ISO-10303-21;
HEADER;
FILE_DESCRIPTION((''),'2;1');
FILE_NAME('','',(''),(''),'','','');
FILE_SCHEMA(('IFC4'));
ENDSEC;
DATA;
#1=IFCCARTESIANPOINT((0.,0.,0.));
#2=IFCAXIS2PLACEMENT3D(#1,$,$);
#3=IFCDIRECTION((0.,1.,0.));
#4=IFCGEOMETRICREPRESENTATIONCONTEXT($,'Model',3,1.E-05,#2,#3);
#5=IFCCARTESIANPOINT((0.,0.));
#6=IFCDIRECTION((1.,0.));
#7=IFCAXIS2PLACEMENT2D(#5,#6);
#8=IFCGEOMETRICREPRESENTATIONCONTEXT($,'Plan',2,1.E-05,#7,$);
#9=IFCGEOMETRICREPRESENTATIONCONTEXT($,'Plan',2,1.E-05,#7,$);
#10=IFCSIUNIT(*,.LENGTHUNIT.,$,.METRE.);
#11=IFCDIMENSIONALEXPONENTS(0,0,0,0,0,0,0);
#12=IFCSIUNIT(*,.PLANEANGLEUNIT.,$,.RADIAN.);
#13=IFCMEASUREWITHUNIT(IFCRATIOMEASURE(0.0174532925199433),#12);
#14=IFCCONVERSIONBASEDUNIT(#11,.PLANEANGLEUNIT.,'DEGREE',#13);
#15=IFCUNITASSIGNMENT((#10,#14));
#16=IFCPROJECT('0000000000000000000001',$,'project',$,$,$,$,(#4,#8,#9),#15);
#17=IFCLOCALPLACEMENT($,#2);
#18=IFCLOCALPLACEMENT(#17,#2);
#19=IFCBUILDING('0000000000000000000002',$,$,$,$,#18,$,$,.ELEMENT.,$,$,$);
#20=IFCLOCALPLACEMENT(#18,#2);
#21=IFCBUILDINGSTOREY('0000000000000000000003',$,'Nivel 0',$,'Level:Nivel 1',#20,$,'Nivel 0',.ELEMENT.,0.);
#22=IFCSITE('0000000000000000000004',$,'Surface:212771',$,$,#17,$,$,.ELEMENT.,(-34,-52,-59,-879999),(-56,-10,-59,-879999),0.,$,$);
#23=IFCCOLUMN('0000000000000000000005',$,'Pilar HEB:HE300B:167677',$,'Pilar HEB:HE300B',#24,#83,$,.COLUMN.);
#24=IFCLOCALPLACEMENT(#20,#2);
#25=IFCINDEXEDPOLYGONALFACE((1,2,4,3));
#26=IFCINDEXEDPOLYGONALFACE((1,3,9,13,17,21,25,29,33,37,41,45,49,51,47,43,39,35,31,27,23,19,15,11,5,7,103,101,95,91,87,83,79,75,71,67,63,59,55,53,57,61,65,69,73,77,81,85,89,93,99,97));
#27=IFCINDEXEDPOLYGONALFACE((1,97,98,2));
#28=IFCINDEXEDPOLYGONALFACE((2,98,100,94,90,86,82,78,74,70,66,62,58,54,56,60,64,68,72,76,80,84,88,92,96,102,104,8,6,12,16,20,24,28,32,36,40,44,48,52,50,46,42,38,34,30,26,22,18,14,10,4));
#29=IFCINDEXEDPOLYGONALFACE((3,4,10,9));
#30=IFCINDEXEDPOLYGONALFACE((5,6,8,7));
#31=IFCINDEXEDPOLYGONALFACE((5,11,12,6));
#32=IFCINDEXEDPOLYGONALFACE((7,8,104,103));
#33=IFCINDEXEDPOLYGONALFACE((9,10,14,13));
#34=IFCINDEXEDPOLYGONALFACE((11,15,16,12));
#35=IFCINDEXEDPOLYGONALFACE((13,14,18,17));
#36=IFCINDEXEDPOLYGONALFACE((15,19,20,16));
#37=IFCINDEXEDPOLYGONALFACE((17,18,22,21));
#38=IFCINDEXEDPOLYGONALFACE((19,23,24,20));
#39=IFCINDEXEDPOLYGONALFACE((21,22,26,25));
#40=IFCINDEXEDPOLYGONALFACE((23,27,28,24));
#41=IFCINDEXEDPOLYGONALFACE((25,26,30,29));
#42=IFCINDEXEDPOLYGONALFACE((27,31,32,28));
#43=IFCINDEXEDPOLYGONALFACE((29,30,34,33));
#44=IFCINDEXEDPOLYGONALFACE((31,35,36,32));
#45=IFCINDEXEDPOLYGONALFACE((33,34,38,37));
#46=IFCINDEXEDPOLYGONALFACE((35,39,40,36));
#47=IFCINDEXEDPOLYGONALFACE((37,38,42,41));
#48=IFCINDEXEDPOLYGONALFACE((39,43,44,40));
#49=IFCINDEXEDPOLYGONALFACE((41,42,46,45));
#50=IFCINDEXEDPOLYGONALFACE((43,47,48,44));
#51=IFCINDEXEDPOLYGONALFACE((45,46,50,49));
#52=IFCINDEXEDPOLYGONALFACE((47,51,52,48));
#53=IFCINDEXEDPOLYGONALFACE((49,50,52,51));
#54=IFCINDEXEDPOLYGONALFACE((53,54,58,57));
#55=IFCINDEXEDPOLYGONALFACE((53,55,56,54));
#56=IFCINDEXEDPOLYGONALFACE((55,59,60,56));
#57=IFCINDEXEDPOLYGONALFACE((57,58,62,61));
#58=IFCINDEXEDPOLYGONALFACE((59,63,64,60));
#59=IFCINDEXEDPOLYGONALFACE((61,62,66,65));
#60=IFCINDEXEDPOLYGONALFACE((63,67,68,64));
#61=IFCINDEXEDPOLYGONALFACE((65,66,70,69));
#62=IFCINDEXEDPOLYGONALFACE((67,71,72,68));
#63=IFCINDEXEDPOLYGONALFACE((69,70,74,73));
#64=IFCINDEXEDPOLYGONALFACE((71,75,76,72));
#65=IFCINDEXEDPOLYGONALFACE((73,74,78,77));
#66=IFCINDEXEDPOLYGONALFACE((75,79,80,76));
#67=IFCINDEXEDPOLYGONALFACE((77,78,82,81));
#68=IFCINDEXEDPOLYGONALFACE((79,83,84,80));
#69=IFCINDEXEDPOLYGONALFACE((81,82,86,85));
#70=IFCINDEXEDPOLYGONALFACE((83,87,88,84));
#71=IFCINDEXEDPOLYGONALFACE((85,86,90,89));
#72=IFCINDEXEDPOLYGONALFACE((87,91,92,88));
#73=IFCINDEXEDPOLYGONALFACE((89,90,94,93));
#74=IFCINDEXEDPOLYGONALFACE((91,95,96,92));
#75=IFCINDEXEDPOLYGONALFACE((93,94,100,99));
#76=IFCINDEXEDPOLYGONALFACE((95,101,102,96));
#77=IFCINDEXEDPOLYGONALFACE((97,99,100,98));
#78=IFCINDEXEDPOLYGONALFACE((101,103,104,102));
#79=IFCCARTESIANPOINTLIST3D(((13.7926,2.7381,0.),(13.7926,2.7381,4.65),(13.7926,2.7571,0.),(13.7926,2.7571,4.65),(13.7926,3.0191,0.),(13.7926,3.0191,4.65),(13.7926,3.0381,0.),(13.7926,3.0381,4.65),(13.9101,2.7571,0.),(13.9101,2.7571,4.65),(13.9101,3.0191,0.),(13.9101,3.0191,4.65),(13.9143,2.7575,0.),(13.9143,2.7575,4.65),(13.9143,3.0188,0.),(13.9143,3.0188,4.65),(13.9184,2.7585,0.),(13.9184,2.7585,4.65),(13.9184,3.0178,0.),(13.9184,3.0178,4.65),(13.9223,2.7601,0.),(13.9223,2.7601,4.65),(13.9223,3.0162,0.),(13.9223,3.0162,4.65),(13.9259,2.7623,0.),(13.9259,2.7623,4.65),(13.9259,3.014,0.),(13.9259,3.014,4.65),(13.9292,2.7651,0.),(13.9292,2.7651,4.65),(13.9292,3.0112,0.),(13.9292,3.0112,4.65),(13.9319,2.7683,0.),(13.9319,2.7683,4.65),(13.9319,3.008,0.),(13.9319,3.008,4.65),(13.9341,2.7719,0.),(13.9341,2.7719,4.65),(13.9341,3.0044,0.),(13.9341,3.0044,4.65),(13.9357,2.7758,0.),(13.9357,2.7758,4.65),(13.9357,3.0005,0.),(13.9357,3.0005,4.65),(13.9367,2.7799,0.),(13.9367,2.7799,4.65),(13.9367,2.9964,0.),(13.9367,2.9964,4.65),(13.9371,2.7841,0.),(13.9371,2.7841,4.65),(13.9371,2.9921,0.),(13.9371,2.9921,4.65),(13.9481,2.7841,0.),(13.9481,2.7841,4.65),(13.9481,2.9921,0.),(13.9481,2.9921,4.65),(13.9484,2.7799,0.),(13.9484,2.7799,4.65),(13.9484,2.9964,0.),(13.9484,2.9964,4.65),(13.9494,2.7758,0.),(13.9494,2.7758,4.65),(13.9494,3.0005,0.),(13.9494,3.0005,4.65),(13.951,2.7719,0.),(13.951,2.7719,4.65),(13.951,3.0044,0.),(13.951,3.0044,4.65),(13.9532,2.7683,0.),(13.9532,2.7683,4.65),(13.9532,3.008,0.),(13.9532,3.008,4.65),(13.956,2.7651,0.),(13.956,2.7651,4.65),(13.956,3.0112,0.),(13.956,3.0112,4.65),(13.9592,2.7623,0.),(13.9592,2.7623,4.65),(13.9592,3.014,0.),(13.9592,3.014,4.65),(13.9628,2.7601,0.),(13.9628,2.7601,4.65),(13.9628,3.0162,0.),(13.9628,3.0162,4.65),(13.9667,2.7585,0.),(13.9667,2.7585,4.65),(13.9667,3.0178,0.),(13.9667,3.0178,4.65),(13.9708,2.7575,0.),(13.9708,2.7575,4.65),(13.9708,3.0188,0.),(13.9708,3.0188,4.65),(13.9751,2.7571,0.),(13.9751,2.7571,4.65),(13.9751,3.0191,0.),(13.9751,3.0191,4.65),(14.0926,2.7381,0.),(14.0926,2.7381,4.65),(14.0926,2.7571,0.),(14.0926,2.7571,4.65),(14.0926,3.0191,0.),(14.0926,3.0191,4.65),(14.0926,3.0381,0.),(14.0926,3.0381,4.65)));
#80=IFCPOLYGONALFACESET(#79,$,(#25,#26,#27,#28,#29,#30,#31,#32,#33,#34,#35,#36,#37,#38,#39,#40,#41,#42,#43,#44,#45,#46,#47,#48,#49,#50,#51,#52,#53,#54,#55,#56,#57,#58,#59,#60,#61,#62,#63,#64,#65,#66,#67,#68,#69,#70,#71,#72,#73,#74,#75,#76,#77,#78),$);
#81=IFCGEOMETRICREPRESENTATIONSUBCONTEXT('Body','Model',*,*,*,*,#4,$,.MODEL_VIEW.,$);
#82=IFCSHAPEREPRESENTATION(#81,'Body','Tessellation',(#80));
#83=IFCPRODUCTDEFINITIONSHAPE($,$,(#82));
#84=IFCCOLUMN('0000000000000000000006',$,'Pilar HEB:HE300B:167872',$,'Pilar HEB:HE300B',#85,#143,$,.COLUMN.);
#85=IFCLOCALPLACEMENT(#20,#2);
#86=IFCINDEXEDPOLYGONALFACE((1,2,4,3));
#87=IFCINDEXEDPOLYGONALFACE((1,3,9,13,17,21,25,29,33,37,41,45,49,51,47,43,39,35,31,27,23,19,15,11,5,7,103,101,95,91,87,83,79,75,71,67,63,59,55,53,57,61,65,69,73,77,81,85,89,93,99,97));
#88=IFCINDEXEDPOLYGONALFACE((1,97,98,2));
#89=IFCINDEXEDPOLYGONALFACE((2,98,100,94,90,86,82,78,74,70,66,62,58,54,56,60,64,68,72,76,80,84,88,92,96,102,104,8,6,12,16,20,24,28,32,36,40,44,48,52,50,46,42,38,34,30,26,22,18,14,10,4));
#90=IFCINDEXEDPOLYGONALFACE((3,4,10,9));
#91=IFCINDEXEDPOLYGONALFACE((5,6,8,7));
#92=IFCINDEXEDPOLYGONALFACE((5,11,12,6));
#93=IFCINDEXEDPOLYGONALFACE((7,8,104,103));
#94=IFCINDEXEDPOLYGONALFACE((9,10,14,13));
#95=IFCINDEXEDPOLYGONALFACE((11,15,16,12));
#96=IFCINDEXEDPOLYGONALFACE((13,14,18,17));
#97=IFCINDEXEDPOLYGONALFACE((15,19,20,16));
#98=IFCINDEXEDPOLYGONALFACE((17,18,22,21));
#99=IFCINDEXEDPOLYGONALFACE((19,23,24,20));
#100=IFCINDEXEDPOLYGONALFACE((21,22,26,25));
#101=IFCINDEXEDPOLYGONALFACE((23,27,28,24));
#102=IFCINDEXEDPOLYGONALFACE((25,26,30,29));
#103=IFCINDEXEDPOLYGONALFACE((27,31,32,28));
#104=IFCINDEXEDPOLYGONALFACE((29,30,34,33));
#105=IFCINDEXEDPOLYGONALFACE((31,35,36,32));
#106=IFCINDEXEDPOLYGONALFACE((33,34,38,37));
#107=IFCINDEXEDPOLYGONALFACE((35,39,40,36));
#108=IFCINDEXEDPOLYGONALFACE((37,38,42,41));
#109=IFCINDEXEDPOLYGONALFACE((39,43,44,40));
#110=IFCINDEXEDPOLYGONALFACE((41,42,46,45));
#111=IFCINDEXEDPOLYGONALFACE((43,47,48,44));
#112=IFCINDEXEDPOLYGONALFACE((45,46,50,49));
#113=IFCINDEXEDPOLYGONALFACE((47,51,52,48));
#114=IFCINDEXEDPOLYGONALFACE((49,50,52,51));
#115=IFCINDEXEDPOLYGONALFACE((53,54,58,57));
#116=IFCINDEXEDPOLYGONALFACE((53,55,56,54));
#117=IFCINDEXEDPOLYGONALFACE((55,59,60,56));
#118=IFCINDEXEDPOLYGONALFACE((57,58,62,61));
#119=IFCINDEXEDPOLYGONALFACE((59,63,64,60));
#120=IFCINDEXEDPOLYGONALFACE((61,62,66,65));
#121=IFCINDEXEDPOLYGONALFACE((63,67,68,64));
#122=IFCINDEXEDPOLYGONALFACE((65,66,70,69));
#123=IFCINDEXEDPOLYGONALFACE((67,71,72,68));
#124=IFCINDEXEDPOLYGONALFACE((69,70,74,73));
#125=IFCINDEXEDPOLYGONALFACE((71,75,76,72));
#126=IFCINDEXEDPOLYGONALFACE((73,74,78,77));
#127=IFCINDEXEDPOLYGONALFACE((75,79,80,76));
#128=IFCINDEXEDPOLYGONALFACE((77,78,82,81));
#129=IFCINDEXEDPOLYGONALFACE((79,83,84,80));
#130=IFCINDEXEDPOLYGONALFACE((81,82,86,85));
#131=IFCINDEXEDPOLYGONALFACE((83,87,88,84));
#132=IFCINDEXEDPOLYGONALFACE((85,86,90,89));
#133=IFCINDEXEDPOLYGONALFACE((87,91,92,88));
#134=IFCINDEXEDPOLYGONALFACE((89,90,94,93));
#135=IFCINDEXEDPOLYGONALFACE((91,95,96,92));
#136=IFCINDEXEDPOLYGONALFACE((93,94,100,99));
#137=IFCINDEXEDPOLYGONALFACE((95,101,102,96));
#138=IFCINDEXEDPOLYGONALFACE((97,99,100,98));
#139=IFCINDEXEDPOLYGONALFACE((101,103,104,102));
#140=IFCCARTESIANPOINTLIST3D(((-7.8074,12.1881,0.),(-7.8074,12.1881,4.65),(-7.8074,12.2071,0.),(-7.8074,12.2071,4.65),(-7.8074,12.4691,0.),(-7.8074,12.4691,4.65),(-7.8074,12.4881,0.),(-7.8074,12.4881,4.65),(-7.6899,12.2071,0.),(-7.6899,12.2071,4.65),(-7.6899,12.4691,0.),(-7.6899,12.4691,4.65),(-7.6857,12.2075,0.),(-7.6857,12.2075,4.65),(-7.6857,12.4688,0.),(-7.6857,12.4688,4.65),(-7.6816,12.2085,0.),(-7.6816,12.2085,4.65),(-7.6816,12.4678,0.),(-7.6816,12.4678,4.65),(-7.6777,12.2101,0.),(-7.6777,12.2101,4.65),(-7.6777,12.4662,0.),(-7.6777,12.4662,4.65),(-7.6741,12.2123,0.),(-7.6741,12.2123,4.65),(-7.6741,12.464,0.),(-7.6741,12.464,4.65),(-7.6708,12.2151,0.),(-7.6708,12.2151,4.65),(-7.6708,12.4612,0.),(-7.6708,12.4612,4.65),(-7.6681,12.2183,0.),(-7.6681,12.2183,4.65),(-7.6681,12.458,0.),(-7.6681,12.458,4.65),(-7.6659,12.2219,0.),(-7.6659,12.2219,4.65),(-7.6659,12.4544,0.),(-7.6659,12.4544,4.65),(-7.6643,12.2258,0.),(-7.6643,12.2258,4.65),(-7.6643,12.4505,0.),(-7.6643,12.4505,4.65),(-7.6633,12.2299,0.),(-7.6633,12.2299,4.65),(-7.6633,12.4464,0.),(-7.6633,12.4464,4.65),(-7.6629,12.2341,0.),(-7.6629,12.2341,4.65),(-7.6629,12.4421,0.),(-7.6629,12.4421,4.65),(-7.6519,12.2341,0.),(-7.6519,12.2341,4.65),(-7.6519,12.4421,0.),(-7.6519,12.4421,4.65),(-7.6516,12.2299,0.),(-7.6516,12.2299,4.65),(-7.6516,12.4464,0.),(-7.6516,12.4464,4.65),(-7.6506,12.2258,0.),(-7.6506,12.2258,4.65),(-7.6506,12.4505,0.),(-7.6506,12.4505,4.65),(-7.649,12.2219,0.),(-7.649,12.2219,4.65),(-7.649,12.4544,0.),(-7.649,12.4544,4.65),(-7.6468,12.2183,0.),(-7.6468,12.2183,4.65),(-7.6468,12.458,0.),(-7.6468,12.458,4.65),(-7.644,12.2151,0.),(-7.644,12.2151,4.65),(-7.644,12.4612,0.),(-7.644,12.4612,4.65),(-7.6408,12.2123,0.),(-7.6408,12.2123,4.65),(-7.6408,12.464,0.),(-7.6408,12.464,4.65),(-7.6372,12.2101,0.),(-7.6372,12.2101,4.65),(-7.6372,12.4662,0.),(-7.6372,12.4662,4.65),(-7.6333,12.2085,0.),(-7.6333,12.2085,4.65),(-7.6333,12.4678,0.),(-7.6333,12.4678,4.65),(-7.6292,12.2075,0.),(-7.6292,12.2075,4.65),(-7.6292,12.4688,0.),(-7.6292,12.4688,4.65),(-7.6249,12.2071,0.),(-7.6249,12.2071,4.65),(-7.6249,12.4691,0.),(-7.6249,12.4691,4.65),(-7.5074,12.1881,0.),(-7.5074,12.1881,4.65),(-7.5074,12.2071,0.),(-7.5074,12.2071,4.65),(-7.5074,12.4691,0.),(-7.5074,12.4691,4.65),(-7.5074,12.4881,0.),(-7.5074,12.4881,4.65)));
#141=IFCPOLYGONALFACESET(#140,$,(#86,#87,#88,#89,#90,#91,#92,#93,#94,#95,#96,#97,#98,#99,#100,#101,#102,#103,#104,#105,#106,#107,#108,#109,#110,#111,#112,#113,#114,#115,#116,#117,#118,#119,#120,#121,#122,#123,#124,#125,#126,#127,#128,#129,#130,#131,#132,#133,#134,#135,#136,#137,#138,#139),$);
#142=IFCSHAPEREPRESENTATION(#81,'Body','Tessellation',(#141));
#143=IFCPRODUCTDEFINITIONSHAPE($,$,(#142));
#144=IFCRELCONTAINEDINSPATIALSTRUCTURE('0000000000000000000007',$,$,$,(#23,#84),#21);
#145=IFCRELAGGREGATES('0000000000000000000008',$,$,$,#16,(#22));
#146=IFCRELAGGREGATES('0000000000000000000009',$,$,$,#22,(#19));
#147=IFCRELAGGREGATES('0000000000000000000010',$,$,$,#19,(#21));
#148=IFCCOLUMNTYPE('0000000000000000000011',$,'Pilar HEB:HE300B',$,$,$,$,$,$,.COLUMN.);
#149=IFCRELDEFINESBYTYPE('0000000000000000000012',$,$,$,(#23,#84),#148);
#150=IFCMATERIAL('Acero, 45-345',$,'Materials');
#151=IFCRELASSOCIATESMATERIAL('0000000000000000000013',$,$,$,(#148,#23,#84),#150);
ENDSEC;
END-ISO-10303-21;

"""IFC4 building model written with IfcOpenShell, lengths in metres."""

from ifc_helpers import new_model, entity, si_unit, converted_unit, direction, frame, origin, origin_2d_with_axis, place, context, subcontext, project, spatial, polyline, outline, extrude, source, transform, mapped, material, type_object, type_shapes, element, save


model = new_model("IFC4")

# Units and contexts
model_context = context("Model", 3, precision=1e-05, world=origin(), true_north=direction((0.0, 1.0, 0.0)))
plan_context_1 = context("Plan", 2, precision=1e-05, world=origin_2d_with_axis())
plan_context_2 = context("Plan", 2, precision=1e-05, world=origin_2d_with_axis())
body_context = subcontext(model_context, "Body", "Model", "MODEL_VIEW")
ifc_project = project(units=[si_unit("LENGTHUNIT", "METRE"), converted_unit("PLANEANGLEUNIT", "DEGREE", entity("IfcRatioMeasure", 0.0174532925199433), si_unit("PLANEANGLEUNIT", "RADIAN"), dimensions=[0, 0, 0, 0, 0, 0, 0])], contexts=[model_context, plan_context_1, plan_context_2])

# Site, building, storey
site_placement = place(None, origin())
site = spatial("IfcSite", under=ifc_project, at=site_placement, Name="Surface:212771", CompositionType="ELEMENT", RefLatitude=(-34, -52, -59, -879999), RefLongitude=(-56, -10, -59, -879999), RefElevation=0.0)
building_placement = place(site_placement, origin())
building = spatial("IfcBuilding", under=site, at=building_placement, CompositionType="ELEMENT")
storey_placement = place(building_placement, origin())
storey = spatial("IfcBuildingStorey", under=building, at=storey_placement, Name="Nivel 0", ObjectType="Level:Nivel 1", LongName="Nivel 0", CompositionType="ELEMENT", Elevation=0.0)

# Columns
ifc_material_1 = material(Name="Acero, 45-345", Category="Materials")
column_type_1 = type_object("IfcColumnType", Name="Pilar HEB:HE300B", PredefinedType="COLUMN", material=ifc_material_1)
shared_shape_1 = source(origin(), body_context, "Body", "SweptSolid", [
    extrude(outline(polyline([(0.1041, 0.0), (0.1084, -0.0001), (0.1125, -0.0009), (0.1165, -0.0023), (0.1203, -0.0043), (0.1236, -0.0069), (0.1265, -0.01), (0.1289, -0.0135), (0.1308, -0.0173), (0.132, -0.0213), (0.1325, -0.0255), (0.1387, -0.1429), (0.1577, -0.1419), (0.1419, 0.1577), (0.1229, 0.1567), (0.1291, 0.0394), (0.129, 0.0351), (0.1282, 0.031), (0.1268, 0.027), (0.1248, 0.0233), (0.1222, 0.0199), (0.1191, 0.017), (0.1156, 0.0146), (0.1118, 0.0127), (0.1078, 0.0115), (0.1036, 0.011), (-0.1041, 0.0), (-0.1084, 0.0001), (-0.1125, 0.0009), (-0.1165, 0.0023), (-0.1203, 0.0043), (-0.1236, 0.0069), (-0.1265, 0.01), (-0.1289, 0.0135), (-0.1308, 0.0173), (-0.132, 0.0213), (-0.1325, 0.0255), (-0.1387, 0.1429), (-0.1577, 0.1419), (-0.1419, -0.1577), (-0.1229, -0.1567), (-0.1291, -0.0394), (-0.129, -0.0351), (-0.1282, -0.031), (-0.1268, -0.027), (-0.1248, -0.0233), (-0.1222, -0.0199), (-0.1191, -0.017), (-0.1156, -0.0146), (-0.1118, -0.0127), (-0.1078, -0.0115), (-0.1036, -0.011), (0.1041, 0.0)])), frame((0.0, 0.0, 0.0), z_axis=(0.0, 0.0, -1.0), x_axis=(0.052811, -0.998605, 0.0)), (0.0, 0.0, -1.0), 4.65),
])
type_shapes(column_type_1, [shared_shape_1])
for number, where, z_axis, x_axis, name in (
    (1, (13.9426, 2.8881, 0.0), (0.0, 0.0, 2.132179), (1.0, 0.0, 0.0), "Pilar HEB:HE300B:167677"),
    (2, (-7.6574, 12.3381, 0.0), (0.0, 0.0, 2.118384), (1.0, 0.0, 0.0), "Pilar HEB:HE300B:167872"),
):
    element("IfcColumn", number, at=place(storey_placement, frame(where, z_axis=z_axis, x_axis=x_axis)), inside=storey, type_object=column_type_1, material=ifc_material_1, Name=name, ObjectType="Pilar HEB:HE300B", PredefinedType="COLUMN", context=body_context, shape_type="MappedRepresentation", body=[
        mapped(shared_shape_1, transform((0.0, 0.0, 0.0), scale=1.0)),
    ])

save(model, "model.ifc")
